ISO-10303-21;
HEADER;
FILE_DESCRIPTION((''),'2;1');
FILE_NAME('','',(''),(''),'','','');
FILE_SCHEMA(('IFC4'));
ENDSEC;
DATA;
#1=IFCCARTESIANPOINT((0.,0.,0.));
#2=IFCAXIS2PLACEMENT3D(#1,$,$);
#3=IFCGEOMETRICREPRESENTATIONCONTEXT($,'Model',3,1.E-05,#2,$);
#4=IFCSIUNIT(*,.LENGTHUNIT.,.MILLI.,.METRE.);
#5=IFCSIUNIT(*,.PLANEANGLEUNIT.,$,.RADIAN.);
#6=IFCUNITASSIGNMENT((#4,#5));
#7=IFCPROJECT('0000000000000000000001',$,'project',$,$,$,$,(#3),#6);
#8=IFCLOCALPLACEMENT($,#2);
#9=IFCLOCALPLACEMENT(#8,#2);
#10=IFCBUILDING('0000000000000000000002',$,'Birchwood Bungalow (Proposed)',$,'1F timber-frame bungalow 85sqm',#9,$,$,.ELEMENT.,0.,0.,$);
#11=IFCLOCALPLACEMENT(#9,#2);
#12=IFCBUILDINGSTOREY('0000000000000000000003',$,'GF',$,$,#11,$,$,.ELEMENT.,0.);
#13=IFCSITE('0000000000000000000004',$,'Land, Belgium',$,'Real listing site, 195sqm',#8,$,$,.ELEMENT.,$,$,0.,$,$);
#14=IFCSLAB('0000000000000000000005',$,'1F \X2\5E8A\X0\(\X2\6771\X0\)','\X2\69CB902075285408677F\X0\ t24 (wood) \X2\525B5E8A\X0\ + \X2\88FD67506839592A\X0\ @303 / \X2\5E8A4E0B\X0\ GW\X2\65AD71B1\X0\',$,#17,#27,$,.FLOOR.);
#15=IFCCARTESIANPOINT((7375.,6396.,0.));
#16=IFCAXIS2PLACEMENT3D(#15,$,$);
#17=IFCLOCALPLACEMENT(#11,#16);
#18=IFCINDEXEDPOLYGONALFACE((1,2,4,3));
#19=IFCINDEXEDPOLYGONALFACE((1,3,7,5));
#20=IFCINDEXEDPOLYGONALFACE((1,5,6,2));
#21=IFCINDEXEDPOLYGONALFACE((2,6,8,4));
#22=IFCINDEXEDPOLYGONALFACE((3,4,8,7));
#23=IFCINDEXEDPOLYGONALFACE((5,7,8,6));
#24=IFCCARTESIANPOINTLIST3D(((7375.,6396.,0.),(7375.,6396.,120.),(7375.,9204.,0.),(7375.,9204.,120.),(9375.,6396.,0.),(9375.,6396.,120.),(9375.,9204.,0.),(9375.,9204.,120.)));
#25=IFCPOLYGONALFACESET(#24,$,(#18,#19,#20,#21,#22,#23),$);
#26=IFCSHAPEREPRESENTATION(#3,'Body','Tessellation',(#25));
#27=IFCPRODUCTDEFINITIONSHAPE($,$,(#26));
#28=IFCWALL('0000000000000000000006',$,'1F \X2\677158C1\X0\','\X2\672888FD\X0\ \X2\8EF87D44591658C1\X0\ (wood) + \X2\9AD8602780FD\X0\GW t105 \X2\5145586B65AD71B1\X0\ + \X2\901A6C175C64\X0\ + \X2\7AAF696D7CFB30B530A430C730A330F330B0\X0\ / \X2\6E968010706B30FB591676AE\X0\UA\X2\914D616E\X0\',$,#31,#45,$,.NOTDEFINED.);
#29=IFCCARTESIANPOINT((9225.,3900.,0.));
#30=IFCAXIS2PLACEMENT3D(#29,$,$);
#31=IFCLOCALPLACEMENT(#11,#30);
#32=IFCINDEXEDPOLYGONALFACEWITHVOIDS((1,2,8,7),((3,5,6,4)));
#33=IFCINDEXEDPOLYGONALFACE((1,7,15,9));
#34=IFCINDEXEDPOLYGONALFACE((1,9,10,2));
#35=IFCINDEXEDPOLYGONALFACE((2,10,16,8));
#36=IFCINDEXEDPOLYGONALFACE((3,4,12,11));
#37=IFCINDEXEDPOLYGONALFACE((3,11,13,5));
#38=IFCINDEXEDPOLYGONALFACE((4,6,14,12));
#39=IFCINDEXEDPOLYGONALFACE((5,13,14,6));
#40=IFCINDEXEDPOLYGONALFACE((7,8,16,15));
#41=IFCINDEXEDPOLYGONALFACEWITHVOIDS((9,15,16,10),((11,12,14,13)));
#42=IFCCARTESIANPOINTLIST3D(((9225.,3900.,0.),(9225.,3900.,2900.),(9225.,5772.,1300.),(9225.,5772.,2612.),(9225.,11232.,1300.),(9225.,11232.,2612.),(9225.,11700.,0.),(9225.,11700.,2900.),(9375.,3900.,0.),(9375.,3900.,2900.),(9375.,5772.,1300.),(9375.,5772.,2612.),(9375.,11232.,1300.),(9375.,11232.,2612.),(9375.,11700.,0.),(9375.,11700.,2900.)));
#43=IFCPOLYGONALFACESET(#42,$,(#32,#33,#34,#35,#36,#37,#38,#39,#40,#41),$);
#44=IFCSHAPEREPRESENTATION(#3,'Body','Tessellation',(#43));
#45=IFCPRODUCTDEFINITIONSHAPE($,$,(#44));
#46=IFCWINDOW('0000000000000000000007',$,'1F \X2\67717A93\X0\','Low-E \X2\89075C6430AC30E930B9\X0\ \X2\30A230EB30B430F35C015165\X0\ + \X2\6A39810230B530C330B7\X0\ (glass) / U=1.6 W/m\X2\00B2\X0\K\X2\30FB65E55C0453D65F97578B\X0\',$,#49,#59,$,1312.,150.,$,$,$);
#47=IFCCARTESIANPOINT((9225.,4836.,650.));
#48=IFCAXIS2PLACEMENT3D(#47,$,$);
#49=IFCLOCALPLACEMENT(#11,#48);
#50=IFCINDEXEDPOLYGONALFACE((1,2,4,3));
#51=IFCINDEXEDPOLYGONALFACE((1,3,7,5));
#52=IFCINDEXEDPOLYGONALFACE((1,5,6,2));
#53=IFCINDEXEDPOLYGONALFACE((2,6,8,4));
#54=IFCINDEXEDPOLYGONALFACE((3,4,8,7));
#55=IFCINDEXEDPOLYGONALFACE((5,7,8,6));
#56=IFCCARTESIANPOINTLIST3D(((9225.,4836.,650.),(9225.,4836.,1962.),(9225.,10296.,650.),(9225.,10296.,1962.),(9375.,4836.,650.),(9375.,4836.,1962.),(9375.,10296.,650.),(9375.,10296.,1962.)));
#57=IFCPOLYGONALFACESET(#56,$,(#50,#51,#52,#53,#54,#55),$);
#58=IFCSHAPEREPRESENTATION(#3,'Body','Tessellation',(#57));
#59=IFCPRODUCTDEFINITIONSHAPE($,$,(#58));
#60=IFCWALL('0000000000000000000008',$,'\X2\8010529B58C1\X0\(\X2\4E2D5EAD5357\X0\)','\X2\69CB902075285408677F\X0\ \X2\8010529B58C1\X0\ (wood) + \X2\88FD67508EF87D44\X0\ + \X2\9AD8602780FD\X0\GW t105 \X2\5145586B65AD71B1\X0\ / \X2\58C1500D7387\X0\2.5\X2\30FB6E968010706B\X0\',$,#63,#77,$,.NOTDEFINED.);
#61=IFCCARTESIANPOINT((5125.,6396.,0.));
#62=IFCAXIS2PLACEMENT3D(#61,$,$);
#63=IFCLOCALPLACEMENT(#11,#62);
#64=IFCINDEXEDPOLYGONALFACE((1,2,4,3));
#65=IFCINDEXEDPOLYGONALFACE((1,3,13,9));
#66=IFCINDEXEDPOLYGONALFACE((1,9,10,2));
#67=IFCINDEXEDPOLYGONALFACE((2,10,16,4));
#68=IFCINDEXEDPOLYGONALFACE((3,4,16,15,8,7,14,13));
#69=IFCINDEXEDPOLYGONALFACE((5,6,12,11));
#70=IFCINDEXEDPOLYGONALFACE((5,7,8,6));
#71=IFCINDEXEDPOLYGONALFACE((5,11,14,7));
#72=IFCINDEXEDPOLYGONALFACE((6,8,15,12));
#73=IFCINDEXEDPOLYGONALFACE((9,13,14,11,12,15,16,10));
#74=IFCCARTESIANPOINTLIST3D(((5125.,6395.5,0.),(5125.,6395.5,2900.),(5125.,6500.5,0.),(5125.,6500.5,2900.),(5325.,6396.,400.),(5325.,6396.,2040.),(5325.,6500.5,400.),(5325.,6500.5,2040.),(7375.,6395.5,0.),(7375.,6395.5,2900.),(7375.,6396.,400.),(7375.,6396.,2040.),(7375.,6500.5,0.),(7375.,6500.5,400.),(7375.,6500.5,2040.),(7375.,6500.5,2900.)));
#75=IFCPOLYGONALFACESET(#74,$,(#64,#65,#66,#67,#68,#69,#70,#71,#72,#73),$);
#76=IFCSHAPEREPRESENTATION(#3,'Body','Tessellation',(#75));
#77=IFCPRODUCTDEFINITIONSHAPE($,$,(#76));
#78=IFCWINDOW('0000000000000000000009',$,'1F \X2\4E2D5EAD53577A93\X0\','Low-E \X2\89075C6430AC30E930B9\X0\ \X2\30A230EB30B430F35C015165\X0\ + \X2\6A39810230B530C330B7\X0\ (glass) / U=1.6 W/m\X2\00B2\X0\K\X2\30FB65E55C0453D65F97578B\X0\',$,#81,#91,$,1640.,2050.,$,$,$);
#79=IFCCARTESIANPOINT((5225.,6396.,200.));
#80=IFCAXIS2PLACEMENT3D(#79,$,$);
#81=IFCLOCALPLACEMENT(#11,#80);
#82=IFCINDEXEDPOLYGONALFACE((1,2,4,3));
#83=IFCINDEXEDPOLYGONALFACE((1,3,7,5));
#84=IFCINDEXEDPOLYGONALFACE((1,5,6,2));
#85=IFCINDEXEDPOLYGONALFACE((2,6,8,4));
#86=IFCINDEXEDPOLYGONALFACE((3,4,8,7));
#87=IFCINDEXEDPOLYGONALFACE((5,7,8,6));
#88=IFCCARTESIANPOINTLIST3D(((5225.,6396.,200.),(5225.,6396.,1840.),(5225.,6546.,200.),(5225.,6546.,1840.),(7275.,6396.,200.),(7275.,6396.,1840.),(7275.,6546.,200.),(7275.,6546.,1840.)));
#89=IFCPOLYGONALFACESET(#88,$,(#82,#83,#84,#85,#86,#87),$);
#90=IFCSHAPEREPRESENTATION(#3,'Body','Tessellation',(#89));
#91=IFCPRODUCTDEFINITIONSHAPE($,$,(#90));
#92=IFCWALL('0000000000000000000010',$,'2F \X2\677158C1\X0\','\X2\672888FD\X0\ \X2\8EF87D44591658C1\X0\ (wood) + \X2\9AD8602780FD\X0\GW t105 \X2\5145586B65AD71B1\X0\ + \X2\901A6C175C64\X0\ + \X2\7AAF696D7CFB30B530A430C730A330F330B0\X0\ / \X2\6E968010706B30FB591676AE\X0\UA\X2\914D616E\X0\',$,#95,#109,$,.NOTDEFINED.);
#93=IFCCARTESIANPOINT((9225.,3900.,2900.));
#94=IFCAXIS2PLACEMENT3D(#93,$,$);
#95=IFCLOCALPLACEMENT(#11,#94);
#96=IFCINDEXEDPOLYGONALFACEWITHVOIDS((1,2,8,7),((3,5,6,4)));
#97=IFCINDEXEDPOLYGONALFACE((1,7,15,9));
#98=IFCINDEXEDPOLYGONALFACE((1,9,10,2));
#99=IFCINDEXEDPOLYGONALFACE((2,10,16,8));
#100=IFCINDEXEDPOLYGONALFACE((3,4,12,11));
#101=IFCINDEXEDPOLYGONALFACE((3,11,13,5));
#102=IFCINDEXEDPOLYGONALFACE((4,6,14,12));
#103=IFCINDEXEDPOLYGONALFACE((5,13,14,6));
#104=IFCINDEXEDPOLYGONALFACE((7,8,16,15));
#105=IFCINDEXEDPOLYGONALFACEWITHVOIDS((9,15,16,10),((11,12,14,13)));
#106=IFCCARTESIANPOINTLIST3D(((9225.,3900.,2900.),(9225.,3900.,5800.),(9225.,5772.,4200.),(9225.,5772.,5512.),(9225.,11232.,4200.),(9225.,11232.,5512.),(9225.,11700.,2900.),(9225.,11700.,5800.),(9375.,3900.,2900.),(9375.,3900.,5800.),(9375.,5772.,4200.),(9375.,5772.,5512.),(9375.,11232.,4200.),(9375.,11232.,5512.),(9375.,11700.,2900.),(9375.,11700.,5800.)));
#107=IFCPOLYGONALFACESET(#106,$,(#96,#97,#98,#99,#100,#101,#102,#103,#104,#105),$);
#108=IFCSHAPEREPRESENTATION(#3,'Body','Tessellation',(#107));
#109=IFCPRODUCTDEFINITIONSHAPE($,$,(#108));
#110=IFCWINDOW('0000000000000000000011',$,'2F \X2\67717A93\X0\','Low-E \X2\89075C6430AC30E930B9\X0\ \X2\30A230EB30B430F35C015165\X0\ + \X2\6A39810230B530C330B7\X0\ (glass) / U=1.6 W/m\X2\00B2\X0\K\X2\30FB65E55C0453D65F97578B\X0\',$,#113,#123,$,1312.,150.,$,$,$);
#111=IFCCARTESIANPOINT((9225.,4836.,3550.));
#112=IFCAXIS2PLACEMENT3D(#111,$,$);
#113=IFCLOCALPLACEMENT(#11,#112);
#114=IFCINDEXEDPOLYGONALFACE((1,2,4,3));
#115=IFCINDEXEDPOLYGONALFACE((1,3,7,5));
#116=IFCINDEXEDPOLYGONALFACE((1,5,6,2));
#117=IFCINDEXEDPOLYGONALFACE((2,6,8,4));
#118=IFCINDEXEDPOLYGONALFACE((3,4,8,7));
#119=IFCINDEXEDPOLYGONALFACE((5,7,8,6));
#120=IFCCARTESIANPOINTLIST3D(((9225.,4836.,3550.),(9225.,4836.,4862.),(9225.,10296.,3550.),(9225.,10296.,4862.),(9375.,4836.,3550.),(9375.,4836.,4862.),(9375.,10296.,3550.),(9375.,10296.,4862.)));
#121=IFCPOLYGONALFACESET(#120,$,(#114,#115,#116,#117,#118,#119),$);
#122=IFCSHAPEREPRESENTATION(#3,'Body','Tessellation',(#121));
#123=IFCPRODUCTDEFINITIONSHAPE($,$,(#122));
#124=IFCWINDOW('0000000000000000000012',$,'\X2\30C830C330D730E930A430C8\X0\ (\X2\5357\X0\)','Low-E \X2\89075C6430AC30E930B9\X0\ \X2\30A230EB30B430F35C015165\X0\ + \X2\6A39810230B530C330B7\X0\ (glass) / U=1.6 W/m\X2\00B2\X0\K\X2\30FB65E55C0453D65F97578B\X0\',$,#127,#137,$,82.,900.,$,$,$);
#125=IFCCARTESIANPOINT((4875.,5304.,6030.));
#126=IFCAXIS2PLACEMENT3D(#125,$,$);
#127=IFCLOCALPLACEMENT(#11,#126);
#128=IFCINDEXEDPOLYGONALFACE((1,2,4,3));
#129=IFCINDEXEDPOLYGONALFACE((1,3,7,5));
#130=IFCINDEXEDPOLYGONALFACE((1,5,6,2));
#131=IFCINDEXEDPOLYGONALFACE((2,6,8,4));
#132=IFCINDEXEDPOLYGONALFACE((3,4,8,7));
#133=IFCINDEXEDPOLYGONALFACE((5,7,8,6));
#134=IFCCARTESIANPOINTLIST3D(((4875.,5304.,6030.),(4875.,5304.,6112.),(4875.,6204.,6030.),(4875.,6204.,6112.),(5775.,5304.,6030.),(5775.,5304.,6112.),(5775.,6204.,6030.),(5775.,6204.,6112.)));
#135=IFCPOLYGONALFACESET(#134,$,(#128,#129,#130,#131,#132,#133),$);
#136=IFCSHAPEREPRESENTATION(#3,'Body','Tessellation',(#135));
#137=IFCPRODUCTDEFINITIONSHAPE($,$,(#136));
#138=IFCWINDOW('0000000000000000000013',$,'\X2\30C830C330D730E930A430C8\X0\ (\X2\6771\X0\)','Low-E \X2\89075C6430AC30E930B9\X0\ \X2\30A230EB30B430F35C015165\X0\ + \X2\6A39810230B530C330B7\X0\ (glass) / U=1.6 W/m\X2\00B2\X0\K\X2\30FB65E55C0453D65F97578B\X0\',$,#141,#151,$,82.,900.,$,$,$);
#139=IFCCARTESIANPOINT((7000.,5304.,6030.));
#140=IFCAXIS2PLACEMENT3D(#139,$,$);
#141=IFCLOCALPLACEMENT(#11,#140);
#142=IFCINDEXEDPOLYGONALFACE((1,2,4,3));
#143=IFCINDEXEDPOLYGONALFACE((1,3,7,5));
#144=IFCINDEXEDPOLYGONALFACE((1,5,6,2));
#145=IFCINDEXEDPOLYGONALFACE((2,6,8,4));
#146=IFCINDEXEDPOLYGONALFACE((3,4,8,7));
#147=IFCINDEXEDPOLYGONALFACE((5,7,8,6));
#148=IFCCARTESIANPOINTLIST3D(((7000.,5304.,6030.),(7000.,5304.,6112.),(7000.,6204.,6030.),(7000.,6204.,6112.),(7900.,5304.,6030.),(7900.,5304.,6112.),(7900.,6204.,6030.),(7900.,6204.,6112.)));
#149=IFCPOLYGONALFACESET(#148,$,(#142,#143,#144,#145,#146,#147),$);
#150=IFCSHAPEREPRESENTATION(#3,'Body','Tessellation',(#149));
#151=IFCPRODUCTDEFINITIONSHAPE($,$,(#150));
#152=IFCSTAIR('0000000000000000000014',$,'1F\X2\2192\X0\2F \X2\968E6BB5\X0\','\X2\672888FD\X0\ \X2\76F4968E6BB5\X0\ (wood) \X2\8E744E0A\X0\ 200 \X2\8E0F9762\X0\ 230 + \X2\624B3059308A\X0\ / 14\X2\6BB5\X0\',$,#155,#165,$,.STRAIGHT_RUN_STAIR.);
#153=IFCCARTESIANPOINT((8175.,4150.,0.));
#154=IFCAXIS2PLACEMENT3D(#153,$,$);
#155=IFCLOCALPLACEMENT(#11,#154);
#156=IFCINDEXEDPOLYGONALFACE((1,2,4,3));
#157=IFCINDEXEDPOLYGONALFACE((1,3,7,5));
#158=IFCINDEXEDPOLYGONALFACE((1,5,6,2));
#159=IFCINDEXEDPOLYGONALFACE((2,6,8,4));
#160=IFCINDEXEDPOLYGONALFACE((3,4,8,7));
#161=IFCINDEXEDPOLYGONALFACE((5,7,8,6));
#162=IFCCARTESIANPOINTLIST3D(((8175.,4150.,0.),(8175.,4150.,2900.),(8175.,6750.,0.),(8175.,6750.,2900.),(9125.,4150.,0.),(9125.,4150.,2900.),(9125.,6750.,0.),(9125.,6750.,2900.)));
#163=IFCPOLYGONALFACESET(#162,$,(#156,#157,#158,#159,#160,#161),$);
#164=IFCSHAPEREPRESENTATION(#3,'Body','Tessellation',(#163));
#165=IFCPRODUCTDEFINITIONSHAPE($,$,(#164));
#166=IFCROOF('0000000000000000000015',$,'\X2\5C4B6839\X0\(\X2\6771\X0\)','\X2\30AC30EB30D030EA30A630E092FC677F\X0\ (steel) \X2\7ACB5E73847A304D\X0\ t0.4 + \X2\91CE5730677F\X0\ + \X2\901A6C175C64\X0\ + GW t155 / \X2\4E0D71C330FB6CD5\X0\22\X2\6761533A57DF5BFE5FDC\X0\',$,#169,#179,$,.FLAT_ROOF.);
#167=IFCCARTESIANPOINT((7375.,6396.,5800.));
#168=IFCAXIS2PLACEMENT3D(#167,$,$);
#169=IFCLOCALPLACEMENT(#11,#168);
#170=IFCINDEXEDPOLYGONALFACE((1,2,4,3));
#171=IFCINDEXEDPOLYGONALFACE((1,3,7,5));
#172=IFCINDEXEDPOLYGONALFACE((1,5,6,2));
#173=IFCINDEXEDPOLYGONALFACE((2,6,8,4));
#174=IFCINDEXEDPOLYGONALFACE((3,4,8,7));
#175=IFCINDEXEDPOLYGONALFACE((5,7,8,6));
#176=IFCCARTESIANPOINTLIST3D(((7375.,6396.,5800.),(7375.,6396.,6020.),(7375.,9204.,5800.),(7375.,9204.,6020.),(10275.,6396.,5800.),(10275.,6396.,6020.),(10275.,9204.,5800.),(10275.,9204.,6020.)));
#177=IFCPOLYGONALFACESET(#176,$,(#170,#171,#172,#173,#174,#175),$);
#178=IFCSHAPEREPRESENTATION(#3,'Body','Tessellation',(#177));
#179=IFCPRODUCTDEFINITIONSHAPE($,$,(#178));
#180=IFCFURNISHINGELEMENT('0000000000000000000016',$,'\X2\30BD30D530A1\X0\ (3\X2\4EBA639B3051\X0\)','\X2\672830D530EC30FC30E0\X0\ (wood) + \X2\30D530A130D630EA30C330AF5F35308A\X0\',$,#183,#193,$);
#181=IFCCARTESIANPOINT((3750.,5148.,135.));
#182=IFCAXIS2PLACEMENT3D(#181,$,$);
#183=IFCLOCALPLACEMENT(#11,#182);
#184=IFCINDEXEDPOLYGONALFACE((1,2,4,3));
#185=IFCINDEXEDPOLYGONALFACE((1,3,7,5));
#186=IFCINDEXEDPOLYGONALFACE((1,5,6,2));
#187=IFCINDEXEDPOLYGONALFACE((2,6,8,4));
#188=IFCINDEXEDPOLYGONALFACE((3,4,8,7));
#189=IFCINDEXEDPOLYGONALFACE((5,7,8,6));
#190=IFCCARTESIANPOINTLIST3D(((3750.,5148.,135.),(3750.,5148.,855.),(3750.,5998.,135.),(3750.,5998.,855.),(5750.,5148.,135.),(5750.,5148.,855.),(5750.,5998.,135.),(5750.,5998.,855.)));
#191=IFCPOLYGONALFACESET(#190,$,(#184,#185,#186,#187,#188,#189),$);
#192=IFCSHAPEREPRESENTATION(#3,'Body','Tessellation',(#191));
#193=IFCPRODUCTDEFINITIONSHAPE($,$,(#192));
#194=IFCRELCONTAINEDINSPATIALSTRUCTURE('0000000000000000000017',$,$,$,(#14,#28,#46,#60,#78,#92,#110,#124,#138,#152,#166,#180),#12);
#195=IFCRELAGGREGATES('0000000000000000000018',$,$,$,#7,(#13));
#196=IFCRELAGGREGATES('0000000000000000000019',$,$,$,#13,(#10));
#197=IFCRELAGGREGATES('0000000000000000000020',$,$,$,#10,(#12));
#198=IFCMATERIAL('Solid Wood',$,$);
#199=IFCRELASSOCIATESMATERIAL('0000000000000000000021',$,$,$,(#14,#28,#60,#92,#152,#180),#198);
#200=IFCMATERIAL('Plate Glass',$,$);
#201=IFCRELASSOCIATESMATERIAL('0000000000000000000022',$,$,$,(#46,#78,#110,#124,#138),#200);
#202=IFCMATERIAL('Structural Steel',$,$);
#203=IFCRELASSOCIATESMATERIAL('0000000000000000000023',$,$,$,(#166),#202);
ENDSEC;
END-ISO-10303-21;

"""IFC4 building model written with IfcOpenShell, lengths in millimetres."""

from ifc_helpers import new_model, si_unit, frame, frame_2d, origin, place, context, project, spatial, rectangle, extrude, material, element, fill, save


model = new_model("IFC4")

# Units and contexts
model_context = context("Model", 3, precision=1e-05, world=origin())
ifc_project = project(units=[si_unit("LENGTHUNIT", "METRE", prefix="MILLI"), si_unit("PLANEANGLEUNIT", "RADIAN")], contexts=[model_context])

# Site, building, storey
site_placement = place(None, origin())
site = spatial("IfcSite", under=ifc_project, at=site_placement, Name="Land, Belgium", ObjectType="Real listing site, 195sqm", CompositionType="ELEMENT", RefElevation=0.0)
building_placement = place(site_placement, origin())
building = spatial("IfcBuilding", under=site, at=building_placement, Name="Birchwood Bungalow (Proposed)", ObjectType="1F timber-frame bungalow 85sqm", CompositionType="ELEMENT", ElevationOfRefHeight=0.0, ElevationOfTerrain=0.0)
storey_placement = place(building_placement, origin())
storey = spatial("IfcBuildingStorey", under=building, at=storey_placement, Name="GF", CompositionType="ELEMENT", Elevation=0.0)

# Slab
ifc_material_1 = material(Name="Solid Wood")
slab_placement = place(storey_placement, frame((7375.0, 6396.0, 0.0)))
element("IfcSlab", 1, at=slab_placement, inside=storey, material=ifc_material_1, Name="1F 床(東)", Description="構造用合板 t24 (wood) 剛床 + 製材根太 @303 / 床下 GW断熱", PredefinedType="FLOOR", context=model_context, shape_type="SweptSolid", body=[
    extrude(rectangle(XDim=2000.0, YDim=2808.0, at=frame_2d((1000.0, 1404.0))), frame((7375.0, 6396.0, 0.0)), (0.0, 0.0, 1.0), 120.0),
])

# Walls, openings, windows
wall_1_placement = place(storey_placement, frame((9225.0, 3900.0, 0.0)))
wall_1 = element("IfcWall", 2, at=wall_1_placement, inside=storey, material=ifc_material_1, Name="1F 東壁", Description="木製 軸組外壁 (wood) + 高性能GW t105 充填断熱 + 通気層 + 窯業系サイディング / 準耐火・外皮UA配慮", PredefinedType="NOTDEFINED", context=model_context, shape_type="SweptSolid", body=[
    extrude(rectangle(XDim=150.0, YDim=7800.0, at=frame_2d((75.0, 3900.0))), frame((9225.0, 3900.0, 0.0)), (0.0, 0.0, 1.0), 2900.0),
])
opening_1_placement = place(storey_placement, frame((9225.0, 4836.0, 650.0)))
opening_1 = element("IfcOpeningElement", 3, at=opening_1_placement, cuts=wall_1, PredefinedType="NOTDEFINED", context=model_context, shape_type="SweptSolid", body=[
    extrude(rectangle(XDim=150.0, YDim=5460.0, at=frame_2d((75.0, 2730.0))), frame((9225.0, 4836.0, 650.0)), (0.0, 0.0, 1.0), 1312.0),
])
ifc_material_2 = material(Name="Plate Glass")
window_1_placement = place(storey_placement, frame((9225.0, 4836.0, 650.0)))
window_1 = element("IfcWindow", 4, at=window_1_placement, inside=storey, material=ifc_material_2, Name="1F 東窓", Description="Low-E 複層ガラス アルゴン封入 + 樹脂サッシ (glass) / U=1.6 W/m²K・日射取得型", OverallHeight=1312.0, OverallWidth=150.0, context=model_context, shape_type="SweptSolid", body=[
    extrude(rectangle(XDim=150.0, YDim=5460.0, at=frame_2d((75.0, 2730.0))), frame((9225.0, 4836.0, 650.0)), (0.0, 0.0, 1.0), 1312.0),
])
fill(opening_1, window_1)
wall_2_placement = place(storey_placement, frame((5125.0, 6396.0, 0.0)))
wall_2 = element("IfcWall", 5, at=wall_2_placement, inside=storey, material=ifc_material_1, Name="耐力壁(中庭南)", Description="構造用合板 耐力壁 (wood) + 製材軸組 + 高性能GW t105 充填断熱 / 壁倍率2.5・準耐火", PredefinedType="NOTDEFINED", context=model_context, shape_type="SweptSolid", body=[
    extrude(rectangle(XDim=2250.0, YDim=105.0, at=frame_2d((1125.0, 52.0))), frame((5125.0, 6396.0, 0.0)), (0.0, 0.0, 1.0), 2900.0),
])
opening_2_placement = place(storey_placement, frame((5225.0, 6396.0, 200.0)))
opening_2 = element("IfcOpeningElement", 6, at=opening_2_placement, cuts=wall_2, PredefinedType="NOTDEFINED", context=model_context, shape_type="SweptSolid", body=[
    extrude(rectangle(XDim=2050.0, YDim=150.0, at=frame_2d((1025.0, 75.0))), frame((5225.0, 6396.0, 200.0)), (0.0, 0.0, 1.0), 1640.0),
])
window_2_placement = place(storey_placement, frame((5225.0, 6396.0, 200.0)))
window_2 = element("IfcWindow", 7, at=window_2_placement, inside=storey, material=ifc_material_2, Name="1F 中庭南窓", Description="Low-E 複層ガラス アルゴン封入 + 樹脂サッシ (glass) / U=1.6 W/m²K・日射取得型", OverallHeight=1640.0, OverallWidth=2050.0, context=model_context, shape_type="SweptSolid", body=[
    extrude(rectangle(XDim=2050.0, YDim=150.0, at=frame_2d((1025.0, 75.0))), frame((5225.0, 6396.0, 200.0)), (0.0, 0.0, 1.0), 1640.0),
])
fill(opening_2, window_2)

# Wall, opening, window
wall_3_placement = place(storey_placement, frame((9225.0, 3900.0, 2900.0)))
wall_3 = element("IfcWall", 8, at=wall_3_placement, inside=storey, material=ifc_material_1, Name="2F 東壁", Description="木製 軸組外壁 (wood) + 高性能GW t105 充填断熱 + 通気層 + 窯業系サイディング / 準耐火・外皮UA配慮", PredefinedType="NOTDEFINED", context=model_context, shape_type="SweptSolid", body=[
    extrude(rectangle(XDim=150.0, YDim=7800.0, at=frame_2d((75.0, 3900.0))), frame((9225.0, 3900.0, 2900.0)), (0.0, 0.0, 1.0), 2900.0),
])
opening_3_placement = place(storey_placement, frame((9225.0, 4836.0, 3550.0)))
opening_3 = element("IfcOpeningElement", 9, at=opening_3_placement, cuts=wall_3, PredefinedType="NOTDEFINED", context=model_context, shape_type="SweptSolid", body=[
    extrude(rectangle(XDim=150.0, YDim=5460.0, at=frame_2d((75.0, 2730.0))), frame((9225.0, 4836.0, 3550.0)), (0.0, 0.0, 1.0), 1312.0),
])
window_3_placement = place(storey_placement, frame((9225.0, 4836.0, 3550.0)))
window_3 = element("IfcWindow", 10, at=window_3_placement, inside=storey, material=ifc_material_2, Name="2F 東窓", Description="Low-E 複層ガラス アルゴン封入 + 樹脂サッシ (glass) / U=1.6 W/m²K・日射取得型", OverallHeight=1312.0, OverallWidth=150.0, context=model_context, shape_type="SweptSolid", body=[
    extrude(rectangle(XDim=150.0, YDim=5460.0, at=frame_2d((75.0, 2730.0))), frame((9225.0, 4836.0, 3550.0)), (0.0, 0.0, 1.0), 1312.0),
])
fill(opening_3, window_3)

# Windows
window_4_placement = place(storey_placement, frame((4875.0, 5304.0, 6030.0)))
element("IfcWindow", 11, at=window_4_placement, inside=storey, material=ifc_material_2, Name="トップライト (南)", Description="Low-E 複層ガラス アルゴン封入 + 樹脂サッシ (glass) / U=1.6 W/m²K・日射取得型", OverallHeight=82.0, OverallWidth=900.0, context=model_context, shape_type="SweptSolid", body=[
    extrude(rectangle(XDim=900.0, YDim=900.0, at=frame_2d((450.0, 450.0))), frame((4875.0, 5304.0, 6030.0)), (0.0, 0.0, 1.0), 82.0),
])
window_5_placement = place(storey_placement, frame((7000.0, 5304.0, 6030.0)))
element("IfcWindow", 12, at=window_5_placement, inside=storey, material=ifc_material_2, Name="トップライト (東)", Description="Low-E 複層ガラス アルゴン封入 + 樹脂サッシ (glass) / U=1.6 W/m²K・日射取得型", OverallHeight=82.0, OverallWidth=900.0, context=model_context, shape_type="SweptSolid", body=[
    extrude(rectangle(XDim=900.0, YDim=900.0, at=frame_2d((450.0, 450.0))), frame((7000.0, 5304.0, 6030.0)), (0.0, 0.0, 1.0), 82.0),
])

# Stair
stair_placement = place(storey_placement, frame((8175.0, 4150.0, 0.0)))
element("IfcStair", 13, at=stair_placement, inside=storey, material=ifc_material_1, Name="1F→2F 階段", Description="木製 直階段 (wood) 蹴上 200 踏面 230 + 手すり / 14段", PredefinedType="STRAIGHT_RUN_STAIR", context=model_context, shape_type="SweptSolid", body=[
    extrude(rectangle(XDim=950.0, YDim=2600.0, at=frame_2d((475.0, 1300.0))), frame((8175.0, 4150.0, 0.0)), (0.0, 0.0, 1.0), 2900.0),
])

# Roof
ifc_material_3 = material(Name="Structural Steel")
roof_placement = place(storey_placement, frame((7375.0, 6396.0, 5800.0)))
element("IfcRoof", 14, at=roof_placement, inside=storey, material=ifc_material_3, Name="屋根(東)", Description="ガルバリウム鋼板 (steel) 立平葺き t0.4 + 野地板 + 通気層 + GW t155 / 不燃・法22条区域対応", PredefinedType="FLAT_ROOF", context=model_context, shape_type="SweptSolid", body=[
    extrude(rectangle(XDim=2900.0, YDim=2808.0, at=frame_2d((1450.0, 1404.0))), frame((7375.0, 6396.0, 5800.0)), (0.0, 0.0, 1.0), 220.0),
])

# Furnishing element
furnishing_1_placement = place(storey_placement, frame((3750.0, 5148.0, 135.0)))
element("IfcFurnishingElement", 15, at=furnishing_1_placement, inside=storey, material=ifc_material_1, Name="ソファ (3人掛け)", Description="木フレーム (wood) + ファブリック張り", context=model_context, shape_type="SweptSolid", body=[
    extrude(rectangle(XDim=2000.0, YDim=850.0, at=frame_2d((1000.0, 425.0))), frame((3750.0, 5148.0, 135.0)), (0.0, 0.0, 1.0), 720.0),
])

save(model, "model.ifc")
